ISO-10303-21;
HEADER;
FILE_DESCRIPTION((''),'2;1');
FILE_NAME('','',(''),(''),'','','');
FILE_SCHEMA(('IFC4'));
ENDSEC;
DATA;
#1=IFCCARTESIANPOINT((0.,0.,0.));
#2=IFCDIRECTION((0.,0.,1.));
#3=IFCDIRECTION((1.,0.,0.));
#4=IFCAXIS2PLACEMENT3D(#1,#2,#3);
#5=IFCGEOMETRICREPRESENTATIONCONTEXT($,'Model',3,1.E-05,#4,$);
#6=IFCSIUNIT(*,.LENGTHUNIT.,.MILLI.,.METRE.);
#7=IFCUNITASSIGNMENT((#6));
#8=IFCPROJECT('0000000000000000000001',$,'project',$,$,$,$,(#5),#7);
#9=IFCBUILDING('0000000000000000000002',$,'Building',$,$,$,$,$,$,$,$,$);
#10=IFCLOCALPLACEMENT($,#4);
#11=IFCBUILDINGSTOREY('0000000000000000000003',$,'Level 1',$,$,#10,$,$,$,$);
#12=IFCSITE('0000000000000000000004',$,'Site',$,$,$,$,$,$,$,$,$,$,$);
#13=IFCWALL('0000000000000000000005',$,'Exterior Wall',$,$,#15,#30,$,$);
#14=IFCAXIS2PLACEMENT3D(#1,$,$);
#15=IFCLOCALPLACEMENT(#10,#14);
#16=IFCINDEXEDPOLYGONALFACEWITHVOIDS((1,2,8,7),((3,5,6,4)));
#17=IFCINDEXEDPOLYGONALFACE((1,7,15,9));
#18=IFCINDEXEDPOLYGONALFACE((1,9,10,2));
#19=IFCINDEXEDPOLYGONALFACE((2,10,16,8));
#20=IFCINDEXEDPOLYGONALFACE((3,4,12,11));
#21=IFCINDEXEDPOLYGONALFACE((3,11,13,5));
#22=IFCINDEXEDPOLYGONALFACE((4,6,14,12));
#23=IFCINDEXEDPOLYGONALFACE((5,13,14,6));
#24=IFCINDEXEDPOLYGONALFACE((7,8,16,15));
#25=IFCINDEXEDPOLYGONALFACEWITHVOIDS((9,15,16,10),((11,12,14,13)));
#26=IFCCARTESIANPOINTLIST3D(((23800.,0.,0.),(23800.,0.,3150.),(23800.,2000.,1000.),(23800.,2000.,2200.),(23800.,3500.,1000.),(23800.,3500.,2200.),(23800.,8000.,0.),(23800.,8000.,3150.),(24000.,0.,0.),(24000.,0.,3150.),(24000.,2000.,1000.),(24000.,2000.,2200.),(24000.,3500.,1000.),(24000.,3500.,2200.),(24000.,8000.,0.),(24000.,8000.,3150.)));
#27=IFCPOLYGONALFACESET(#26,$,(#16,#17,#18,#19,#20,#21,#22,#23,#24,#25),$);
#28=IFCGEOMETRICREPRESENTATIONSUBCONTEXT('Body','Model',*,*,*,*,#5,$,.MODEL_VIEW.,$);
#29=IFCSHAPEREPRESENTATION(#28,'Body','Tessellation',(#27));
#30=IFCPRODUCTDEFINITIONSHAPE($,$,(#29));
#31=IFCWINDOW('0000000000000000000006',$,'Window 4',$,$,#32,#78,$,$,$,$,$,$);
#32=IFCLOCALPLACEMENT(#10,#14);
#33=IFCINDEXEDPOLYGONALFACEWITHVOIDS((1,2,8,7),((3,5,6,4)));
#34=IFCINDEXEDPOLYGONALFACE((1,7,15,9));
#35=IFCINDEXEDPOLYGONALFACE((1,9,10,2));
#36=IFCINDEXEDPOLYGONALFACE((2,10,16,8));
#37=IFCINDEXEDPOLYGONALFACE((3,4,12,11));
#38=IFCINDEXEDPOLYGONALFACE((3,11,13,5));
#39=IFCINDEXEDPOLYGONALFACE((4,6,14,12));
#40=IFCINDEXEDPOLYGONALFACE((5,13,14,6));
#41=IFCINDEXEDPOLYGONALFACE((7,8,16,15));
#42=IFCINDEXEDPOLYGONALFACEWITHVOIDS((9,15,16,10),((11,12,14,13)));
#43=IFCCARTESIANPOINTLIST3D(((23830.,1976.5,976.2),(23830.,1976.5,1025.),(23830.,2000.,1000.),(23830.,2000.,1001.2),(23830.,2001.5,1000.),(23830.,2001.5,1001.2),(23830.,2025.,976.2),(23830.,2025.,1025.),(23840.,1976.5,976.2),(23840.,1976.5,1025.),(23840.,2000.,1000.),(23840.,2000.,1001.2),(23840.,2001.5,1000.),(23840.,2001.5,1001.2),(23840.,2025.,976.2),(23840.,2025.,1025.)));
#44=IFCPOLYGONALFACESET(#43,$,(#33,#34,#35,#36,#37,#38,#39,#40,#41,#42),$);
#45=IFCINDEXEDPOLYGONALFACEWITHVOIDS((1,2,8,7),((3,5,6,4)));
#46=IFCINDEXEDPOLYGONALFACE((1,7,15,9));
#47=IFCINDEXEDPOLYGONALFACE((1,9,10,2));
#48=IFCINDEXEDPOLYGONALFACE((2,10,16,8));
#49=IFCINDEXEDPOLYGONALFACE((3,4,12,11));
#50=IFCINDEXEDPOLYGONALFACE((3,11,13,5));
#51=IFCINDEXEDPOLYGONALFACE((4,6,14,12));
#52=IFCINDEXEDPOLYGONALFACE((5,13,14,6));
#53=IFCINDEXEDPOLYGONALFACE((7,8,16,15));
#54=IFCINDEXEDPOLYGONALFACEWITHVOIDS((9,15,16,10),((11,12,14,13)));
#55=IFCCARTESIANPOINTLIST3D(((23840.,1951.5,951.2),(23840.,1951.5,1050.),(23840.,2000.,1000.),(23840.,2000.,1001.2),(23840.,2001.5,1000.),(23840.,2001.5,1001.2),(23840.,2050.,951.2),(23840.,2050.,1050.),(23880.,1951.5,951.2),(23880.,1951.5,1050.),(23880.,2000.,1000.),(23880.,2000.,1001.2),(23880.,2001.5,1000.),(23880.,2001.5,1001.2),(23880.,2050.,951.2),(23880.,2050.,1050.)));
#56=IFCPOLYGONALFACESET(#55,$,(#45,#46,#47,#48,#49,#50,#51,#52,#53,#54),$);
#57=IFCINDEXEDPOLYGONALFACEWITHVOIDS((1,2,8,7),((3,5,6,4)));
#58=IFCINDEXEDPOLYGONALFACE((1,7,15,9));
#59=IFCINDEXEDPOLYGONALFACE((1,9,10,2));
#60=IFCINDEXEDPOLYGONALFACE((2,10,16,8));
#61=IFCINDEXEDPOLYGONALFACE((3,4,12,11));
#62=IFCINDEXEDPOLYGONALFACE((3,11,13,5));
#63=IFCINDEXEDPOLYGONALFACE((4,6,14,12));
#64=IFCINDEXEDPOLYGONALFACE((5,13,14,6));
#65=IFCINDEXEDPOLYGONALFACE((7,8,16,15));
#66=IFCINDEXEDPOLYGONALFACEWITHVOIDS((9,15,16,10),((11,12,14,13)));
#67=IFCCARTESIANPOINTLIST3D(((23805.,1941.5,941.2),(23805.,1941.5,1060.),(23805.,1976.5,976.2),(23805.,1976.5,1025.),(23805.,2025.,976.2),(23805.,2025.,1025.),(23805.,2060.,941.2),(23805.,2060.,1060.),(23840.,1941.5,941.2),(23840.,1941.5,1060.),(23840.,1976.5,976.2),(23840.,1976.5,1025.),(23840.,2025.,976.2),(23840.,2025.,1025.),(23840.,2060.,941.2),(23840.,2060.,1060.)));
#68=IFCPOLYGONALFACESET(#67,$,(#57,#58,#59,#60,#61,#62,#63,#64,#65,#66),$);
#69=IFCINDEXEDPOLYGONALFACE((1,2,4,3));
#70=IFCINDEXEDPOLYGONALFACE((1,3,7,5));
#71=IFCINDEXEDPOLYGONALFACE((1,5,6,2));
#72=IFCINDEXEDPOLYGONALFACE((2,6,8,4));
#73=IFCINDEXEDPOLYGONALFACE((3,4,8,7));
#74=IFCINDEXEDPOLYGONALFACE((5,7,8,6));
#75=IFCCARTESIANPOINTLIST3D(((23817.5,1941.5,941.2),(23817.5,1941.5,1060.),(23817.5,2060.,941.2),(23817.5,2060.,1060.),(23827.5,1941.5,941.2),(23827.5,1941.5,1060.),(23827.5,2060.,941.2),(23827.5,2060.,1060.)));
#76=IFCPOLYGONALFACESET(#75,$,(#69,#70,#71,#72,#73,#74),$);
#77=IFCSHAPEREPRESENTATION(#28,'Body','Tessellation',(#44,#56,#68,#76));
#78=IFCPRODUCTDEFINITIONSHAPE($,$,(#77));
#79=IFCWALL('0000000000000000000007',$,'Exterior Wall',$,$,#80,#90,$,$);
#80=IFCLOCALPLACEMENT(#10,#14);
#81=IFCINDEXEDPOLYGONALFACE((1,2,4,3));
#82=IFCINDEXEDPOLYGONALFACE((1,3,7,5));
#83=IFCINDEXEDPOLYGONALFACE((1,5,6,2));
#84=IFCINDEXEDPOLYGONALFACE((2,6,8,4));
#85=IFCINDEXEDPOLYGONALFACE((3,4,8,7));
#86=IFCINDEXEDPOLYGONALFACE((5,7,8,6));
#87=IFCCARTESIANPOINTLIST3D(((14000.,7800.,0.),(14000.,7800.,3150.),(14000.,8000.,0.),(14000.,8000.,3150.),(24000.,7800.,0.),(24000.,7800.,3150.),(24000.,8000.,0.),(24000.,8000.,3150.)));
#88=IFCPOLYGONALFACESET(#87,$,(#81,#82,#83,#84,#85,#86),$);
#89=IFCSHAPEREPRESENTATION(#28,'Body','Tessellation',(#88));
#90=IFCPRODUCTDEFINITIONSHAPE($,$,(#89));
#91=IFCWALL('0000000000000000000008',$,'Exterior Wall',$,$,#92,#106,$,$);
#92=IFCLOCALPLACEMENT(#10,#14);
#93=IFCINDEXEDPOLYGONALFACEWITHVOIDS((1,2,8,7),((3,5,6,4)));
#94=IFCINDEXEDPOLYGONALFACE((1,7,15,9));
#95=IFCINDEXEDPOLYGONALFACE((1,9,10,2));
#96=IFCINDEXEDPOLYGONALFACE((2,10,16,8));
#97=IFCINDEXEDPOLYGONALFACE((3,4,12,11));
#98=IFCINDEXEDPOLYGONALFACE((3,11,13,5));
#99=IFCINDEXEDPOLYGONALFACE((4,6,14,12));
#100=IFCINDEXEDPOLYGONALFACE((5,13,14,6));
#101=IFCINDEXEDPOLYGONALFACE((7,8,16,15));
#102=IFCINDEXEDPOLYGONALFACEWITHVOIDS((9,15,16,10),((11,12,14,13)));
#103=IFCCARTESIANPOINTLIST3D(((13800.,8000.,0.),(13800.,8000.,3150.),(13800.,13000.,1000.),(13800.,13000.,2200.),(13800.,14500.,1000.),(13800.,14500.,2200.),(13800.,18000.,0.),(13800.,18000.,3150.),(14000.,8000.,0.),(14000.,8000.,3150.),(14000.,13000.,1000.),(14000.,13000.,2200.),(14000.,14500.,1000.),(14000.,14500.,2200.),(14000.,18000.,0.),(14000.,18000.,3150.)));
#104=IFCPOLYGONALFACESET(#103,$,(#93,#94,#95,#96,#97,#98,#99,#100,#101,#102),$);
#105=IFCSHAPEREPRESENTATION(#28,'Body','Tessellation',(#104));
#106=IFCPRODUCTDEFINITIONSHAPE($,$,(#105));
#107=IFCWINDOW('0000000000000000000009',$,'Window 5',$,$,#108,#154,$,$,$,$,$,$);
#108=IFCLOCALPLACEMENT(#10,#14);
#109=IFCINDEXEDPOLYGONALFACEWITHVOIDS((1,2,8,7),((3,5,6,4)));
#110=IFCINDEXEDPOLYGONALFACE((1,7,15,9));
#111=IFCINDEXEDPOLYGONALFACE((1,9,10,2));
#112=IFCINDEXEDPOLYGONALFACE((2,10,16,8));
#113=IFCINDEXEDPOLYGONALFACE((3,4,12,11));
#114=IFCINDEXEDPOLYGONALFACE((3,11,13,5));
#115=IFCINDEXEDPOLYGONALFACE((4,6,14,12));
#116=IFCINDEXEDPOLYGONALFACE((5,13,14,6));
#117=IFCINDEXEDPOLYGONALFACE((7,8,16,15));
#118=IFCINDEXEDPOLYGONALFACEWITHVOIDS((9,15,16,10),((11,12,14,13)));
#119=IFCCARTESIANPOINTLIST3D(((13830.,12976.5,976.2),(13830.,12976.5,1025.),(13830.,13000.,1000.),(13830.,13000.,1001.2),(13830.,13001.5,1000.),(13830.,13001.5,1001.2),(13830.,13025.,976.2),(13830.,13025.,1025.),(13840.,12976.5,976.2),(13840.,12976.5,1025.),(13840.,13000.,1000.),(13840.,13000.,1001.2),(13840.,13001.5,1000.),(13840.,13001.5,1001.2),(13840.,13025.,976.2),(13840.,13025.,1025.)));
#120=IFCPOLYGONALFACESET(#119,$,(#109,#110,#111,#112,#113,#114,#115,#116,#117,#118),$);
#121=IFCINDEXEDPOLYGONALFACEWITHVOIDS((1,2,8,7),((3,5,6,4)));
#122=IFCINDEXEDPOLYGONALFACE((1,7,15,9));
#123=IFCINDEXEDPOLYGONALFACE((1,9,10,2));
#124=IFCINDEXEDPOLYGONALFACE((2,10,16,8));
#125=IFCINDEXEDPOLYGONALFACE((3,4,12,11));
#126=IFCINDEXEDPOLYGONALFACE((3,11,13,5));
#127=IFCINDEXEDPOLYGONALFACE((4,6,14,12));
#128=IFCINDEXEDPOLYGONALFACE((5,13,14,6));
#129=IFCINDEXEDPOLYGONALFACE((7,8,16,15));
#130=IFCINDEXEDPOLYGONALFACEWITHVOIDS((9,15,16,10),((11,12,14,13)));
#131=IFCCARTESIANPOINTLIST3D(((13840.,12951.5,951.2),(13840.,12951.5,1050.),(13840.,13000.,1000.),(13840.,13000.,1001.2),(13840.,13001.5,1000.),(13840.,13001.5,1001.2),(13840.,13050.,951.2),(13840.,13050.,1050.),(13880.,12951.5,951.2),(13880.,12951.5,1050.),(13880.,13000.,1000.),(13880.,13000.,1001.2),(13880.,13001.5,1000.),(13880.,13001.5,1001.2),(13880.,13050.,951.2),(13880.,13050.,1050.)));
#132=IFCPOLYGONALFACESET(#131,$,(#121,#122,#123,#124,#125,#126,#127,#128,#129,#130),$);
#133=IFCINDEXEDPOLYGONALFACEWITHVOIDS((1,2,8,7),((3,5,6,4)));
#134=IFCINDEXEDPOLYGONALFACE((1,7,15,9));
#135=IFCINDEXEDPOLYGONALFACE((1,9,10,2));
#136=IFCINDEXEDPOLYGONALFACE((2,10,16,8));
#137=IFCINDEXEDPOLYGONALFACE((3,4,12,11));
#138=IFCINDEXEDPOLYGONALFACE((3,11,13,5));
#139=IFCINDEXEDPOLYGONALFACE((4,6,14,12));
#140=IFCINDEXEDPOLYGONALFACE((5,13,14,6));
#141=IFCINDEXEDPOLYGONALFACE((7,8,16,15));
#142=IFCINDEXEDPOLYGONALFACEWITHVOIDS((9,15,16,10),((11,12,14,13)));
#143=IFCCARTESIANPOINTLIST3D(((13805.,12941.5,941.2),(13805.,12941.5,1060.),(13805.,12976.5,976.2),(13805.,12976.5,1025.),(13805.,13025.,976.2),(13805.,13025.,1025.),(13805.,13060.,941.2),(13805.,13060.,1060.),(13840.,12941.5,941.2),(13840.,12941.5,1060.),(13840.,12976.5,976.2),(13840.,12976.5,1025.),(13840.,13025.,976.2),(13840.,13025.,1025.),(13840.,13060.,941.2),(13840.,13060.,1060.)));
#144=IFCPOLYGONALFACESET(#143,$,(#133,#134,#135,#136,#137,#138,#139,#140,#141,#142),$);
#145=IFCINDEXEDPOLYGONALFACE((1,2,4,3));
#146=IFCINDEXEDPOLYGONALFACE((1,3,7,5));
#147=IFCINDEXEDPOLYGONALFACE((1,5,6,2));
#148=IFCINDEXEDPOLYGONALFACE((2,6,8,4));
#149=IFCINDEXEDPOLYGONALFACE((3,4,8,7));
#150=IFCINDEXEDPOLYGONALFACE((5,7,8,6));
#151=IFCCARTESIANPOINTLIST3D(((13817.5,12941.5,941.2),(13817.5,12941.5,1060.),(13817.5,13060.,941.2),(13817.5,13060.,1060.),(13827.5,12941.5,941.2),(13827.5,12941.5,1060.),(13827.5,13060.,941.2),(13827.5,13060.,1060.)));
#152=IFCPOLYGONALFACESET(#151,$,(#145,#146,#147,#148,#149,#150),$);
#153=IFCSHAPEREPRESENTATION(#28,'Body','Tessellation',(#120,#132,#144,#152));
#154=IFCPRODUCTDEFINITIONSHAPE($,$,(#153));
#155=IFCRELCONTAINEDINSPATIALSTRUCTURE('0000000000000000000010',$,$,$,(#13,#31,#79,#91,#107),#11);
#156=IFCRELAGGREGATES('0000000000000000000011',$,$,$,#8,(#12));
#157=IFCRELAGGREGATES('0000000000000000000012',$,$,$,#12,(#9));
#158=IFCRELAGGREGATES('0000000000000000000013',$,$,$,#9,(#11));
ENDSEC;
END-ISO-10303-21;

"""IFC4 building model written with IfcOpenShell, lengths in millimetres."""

from ifc_helpers import new_model, si_unit, frame, origin_with_axes, place, context, subcontext, project, spatial, line, indexed_curve, outline, extrude, element, fill, save


model = new_model("IFC4")

# Units and contexts
model_context = context("Model", 3, precision=1e-05, world=origin_with_axes())
body_context = subcontext(model_context, "Body", "Model", "MODEL_VIEW")
ifc_project = project(units=[si_unit("LENGTHUNIT", "METRE", prefix="MILLI")], contexts=[model_context])

# Site, building, storey
site = spatial("IfcSite", under=ifc_project, Name="Site")
building = spatial("IfcBuilding", under=site, Name="Building")
storey_placement = place(None, origin_with_axes())
storey = spatial("IfcBuildingStorey", under=building, at=storey_placement, Name="Level 1")

# Wall, opening, window
wall_1_placement = place(storey_placement, frame((24000.0, 0.0, 0.0), z_axis=(0.0, 0.0, 1.0), x_axis=(0.0, 1.0, 0.0)))
wall_1 = element("IfcWall", 1, at=wall_1_placement, inside=storey, Name="Exterior Wall", context=body_context, shape_type="SweptSolid", body=[
    extrude(outline(indexed_curve([(0.0, 0.0), (0.0, 200.0), (8000.0, 200.0), (8000.0, 0.0), (0.0, 0.0)], self_intersect=False)), origin_with_axes(), (0.0, 0.0, 1.0), 3150.0),
])
opening_1_placement = place(wall_1_placement, frame((2000.0, -100.0, 1000.0), z_axis=(0.0, 0.0, 1.0), x_axis=(1.0, 0.0, 0.0)))
opening_1 = element("IfcOpeningElement", 2, at=opening_1_placement, cuts=wall_1, context=body_context, shape_type="SweptSolid", body=[
    extrude(outline(indexed_curve([(0.0, 0.0), (0.0, 400.0), (1500.0, 400.0), (1500.0, 0.0), (0.0, 0.0)], self_intersect=False)), origin_with_axes(), (0.0, 0.0, 1.0), 1200.0),
])
window_1_placement = place(opening_1_placement, frame((0.0, 170.0, 0.0), z_axis=(0.0, 0.0, 1.0), x_axis=(1.0, 0.0, 0.0)))
window_1 = element("IfcWindow", 3, at=window_1_placement, inside=storey, Name="Window 4", context=body_context, shape_type="SweptSolid", body=[
    extrude(outline(indexed_curve([(0.0, 0.0), (1.5, 0.0), (1.5, 1.2), (0.0, 1.2)], segments=[line(1, 2, 3, 4, 1)]), holes=[indexed_curve([(25.0, 25.0), (-23.5, 25.0), (-23.5, -23.8), (25.0, -23.8)], segments=[line(1, 2, 3, 4, 1)])]), frame((0.0, 90.0, 0.0), z_axis=(0.0, -1.0, 0.0), x_axis=(1.0, 0.0, 0.0)), (0.0, 0.0, -1.0), 10.0),
    extrude(outline(indexed_curve([(0.0, 0.0), (1.5, 0.0), (1.5, 1.2), (0.0, 1.2)], segments=[line(1, 2, 3, 4, 1)]), holes=[indexed_curve([(50.0, 50.0), (-48.5, 50.0), (-48.5, -48.8), (50.0, -48.8)], segments=[line(1, 2, 3, 4, 1)])]), frame((0.0, 50.0, 0.0), z_axis=(0.0, -1.0, 0.0), x_axis=(1.0, 0.0, 0.0)), (0.0, 0.0, -1.0), 40.0),
    extrude(outline(indexed_curve([(0.0, 0.0), (-48.5, 0.0), (-48.5, -48.8), (0.0, -48.8)], segments=[line(1, 2, 3, 4, 1)]), holes=[indexed_curve([(35.0, 35.0), (-83.5, 35.0), (-83.5, -83.8), (35.0, -83.8)], segments=[line(1, 2, 3, 4, 1)])]), frame((25.0, 90.0, 25.0), z_axis=(0.0, -1.0, 0.0), x_axis=(1.0, 0.0, 0.0)), (0.0, 0.0, -1.0), 35.0),
    extrude(outline(indexed_curve([(35.0, 35.0), (-83.5, 35.0), (-83.5, -83.8), (35.0, -83.8)], segments=[line(1, 2, 3, 4, 1)])), frame((25.0, 102.5, 25.0), z_axis=(0.0, -1.0, 0.0), x_axis=(1.0, 0.0, 0.0)), (0.0, 0.0, -1.0), 10.0),
])
fill(opening_1, window_1)

# Wall
wall_2_placement = place(storey_placement, frame((24000.0, 8000.0, 0.0), z_axis=(0.0, 0.0, 1.0), x_axis=(-1.0, 0.0, 0.0)))
element("IfcWall", 4, at=wall_2_placement, inside=storey, Name="Exterior Wall", context=body_context, shape_type="SweptSolid", body=[
    extrude(outline(indexed_curve([(0.0, 0.0), (0.0, 200.0), (10000.0, 200.0), (10000.0, 0.0), (0.0, 0.0)], self_intersect=False)), origin_with_axes(), (0.0, 0.0, 1.0), 3150.0),
])

# Wall, opening, window
wall_3_placement = place(storey_placement, frame((14000.0, 8000.0, 0.0), z_axis=(0.0, 0.0, 1.0), x_axis=(0.0, 1.0, 0.0)))
wall_3 = element("IfcWall", 5, at=wall_3_placement, inside=storey, Name="Exterior Wall", context=body_context, shape_type="SweptSolid", body=[
    extrude(outline(indexed_curve([(0.0, 0.0), (0.0, 200.0), (10000.0, 200.0), (10000.0, 0.0), (0.0, 0.0)], self_intersect=False)), origin_with_axes(), (0.0, 0.0, 1.0), 3150.0),
])
opening_2_placement = place(wall_3_placement, frame((5000.0, -100.0, 1000.0), z_axis=(0.0, 0.0, 1.0), x_axis=(1.0, 0.0, 0.0)))
opening_2 = element("IfcOpeningElement", 6, at=opening_2_placement, cuts=wall_3, context=body_context, shape_type="SweptSolid", body=[
    extrude(outline(indexed_curve([(0.0, 0.0), (0.0, 400.0), (1500.0, 400.0), (1500.0, 0.0), (0.0, 0.0)], self_intersect=False)), origin_with_axes(), (0.0, 0.0, 1.0), 1200.0),
])
window_2_placement = place(opening_2_placement, frame((0.0, 170.0, 0.0), z_axis=(0.0, 0.0, 1.0), x_axis=(1.0, 0.0, 0.0)))
window_2 = element("IfcWindow", 7, at=window_2_placement, inside=storey, Name="Window 5", context=body_context, shape_type="SweptSolid", body=[
    extrude(outline(indexed_curve([(0.0, 0.0), (1.5, 0.0), (1.5, 1.2), (0.0, 1.2)], segments=[line(1, 2, 3, 4, 1)]), holes=[indexed_curve([(25.0, 25.0), (-23.5, 25.0), (-23.5, -23.8), (25.0, -23.8)], segments=[line(1, 2, 3, 4, 1)])]), frame((0.0, 90.0, 0.0), z_axis=(0.0, -1.0, 0.0), x_axis=(1.0, 0.0, 0.0)), (0.0, 0.0, -1.0), 10.0),
    extrude(outline(indexed_curve([(0.0, 0.0), (1.5, 0.0), (1.5, 1.2), (0.0, 1.2)], segments=[line(1, 2, 3, 4, 1)]), holes=[indexed_curve([(50.0, 50.0), (-48.5, 50.0), (-48.5, -48.8), (50.0, -48.8)], segments=[line(1, 2, 3, 4, 1)])]), frame((0.0, 50.0, 0.0), z_axis=(0.0, -1.0, 0.0), x_axis=(1.0, 0.0, 0.0)), (0.0, 0.0, -1.0), 40.0),
    extrude(outline(indexed_curve([(0.0, 0.0), (-48.5, 0.0), (-48.5, -48.8), (0.0, -48.8)], segments=[line(1, 2, 3, 4, 1)]), holes=[indexed_curve([(35.0, 35.0), (-83.5, 35.0), (-83.5, -83.8), (35.0, -83.8)], segments=[line(1, 2, 3, 4, 1)])]), frame((25.0, 90.0, 25.0), z_axis=(0.0, -1.0, 0.0), x_axis=(1.0, 0.0, 0.0)), (0.0, 0.0, -1.0), 35.0),
    extrude(outline(indexed_curve([(35.0, 35.0), (-83.5, 35.0), (-83.5, -83.8), (35.0, -83.8)], segments=[line(1, 2, 3, 4, 1)])), frame((25.0, 102.5, 25.0), z_axis=(0.0, -1.0, 0.0), x_axis=(1.0, 0.0, 0.0)), (0.0, 0.0, -1.0), 10.0),
])
fill(opening_2, window_2)

save(model, "model.ifc")
